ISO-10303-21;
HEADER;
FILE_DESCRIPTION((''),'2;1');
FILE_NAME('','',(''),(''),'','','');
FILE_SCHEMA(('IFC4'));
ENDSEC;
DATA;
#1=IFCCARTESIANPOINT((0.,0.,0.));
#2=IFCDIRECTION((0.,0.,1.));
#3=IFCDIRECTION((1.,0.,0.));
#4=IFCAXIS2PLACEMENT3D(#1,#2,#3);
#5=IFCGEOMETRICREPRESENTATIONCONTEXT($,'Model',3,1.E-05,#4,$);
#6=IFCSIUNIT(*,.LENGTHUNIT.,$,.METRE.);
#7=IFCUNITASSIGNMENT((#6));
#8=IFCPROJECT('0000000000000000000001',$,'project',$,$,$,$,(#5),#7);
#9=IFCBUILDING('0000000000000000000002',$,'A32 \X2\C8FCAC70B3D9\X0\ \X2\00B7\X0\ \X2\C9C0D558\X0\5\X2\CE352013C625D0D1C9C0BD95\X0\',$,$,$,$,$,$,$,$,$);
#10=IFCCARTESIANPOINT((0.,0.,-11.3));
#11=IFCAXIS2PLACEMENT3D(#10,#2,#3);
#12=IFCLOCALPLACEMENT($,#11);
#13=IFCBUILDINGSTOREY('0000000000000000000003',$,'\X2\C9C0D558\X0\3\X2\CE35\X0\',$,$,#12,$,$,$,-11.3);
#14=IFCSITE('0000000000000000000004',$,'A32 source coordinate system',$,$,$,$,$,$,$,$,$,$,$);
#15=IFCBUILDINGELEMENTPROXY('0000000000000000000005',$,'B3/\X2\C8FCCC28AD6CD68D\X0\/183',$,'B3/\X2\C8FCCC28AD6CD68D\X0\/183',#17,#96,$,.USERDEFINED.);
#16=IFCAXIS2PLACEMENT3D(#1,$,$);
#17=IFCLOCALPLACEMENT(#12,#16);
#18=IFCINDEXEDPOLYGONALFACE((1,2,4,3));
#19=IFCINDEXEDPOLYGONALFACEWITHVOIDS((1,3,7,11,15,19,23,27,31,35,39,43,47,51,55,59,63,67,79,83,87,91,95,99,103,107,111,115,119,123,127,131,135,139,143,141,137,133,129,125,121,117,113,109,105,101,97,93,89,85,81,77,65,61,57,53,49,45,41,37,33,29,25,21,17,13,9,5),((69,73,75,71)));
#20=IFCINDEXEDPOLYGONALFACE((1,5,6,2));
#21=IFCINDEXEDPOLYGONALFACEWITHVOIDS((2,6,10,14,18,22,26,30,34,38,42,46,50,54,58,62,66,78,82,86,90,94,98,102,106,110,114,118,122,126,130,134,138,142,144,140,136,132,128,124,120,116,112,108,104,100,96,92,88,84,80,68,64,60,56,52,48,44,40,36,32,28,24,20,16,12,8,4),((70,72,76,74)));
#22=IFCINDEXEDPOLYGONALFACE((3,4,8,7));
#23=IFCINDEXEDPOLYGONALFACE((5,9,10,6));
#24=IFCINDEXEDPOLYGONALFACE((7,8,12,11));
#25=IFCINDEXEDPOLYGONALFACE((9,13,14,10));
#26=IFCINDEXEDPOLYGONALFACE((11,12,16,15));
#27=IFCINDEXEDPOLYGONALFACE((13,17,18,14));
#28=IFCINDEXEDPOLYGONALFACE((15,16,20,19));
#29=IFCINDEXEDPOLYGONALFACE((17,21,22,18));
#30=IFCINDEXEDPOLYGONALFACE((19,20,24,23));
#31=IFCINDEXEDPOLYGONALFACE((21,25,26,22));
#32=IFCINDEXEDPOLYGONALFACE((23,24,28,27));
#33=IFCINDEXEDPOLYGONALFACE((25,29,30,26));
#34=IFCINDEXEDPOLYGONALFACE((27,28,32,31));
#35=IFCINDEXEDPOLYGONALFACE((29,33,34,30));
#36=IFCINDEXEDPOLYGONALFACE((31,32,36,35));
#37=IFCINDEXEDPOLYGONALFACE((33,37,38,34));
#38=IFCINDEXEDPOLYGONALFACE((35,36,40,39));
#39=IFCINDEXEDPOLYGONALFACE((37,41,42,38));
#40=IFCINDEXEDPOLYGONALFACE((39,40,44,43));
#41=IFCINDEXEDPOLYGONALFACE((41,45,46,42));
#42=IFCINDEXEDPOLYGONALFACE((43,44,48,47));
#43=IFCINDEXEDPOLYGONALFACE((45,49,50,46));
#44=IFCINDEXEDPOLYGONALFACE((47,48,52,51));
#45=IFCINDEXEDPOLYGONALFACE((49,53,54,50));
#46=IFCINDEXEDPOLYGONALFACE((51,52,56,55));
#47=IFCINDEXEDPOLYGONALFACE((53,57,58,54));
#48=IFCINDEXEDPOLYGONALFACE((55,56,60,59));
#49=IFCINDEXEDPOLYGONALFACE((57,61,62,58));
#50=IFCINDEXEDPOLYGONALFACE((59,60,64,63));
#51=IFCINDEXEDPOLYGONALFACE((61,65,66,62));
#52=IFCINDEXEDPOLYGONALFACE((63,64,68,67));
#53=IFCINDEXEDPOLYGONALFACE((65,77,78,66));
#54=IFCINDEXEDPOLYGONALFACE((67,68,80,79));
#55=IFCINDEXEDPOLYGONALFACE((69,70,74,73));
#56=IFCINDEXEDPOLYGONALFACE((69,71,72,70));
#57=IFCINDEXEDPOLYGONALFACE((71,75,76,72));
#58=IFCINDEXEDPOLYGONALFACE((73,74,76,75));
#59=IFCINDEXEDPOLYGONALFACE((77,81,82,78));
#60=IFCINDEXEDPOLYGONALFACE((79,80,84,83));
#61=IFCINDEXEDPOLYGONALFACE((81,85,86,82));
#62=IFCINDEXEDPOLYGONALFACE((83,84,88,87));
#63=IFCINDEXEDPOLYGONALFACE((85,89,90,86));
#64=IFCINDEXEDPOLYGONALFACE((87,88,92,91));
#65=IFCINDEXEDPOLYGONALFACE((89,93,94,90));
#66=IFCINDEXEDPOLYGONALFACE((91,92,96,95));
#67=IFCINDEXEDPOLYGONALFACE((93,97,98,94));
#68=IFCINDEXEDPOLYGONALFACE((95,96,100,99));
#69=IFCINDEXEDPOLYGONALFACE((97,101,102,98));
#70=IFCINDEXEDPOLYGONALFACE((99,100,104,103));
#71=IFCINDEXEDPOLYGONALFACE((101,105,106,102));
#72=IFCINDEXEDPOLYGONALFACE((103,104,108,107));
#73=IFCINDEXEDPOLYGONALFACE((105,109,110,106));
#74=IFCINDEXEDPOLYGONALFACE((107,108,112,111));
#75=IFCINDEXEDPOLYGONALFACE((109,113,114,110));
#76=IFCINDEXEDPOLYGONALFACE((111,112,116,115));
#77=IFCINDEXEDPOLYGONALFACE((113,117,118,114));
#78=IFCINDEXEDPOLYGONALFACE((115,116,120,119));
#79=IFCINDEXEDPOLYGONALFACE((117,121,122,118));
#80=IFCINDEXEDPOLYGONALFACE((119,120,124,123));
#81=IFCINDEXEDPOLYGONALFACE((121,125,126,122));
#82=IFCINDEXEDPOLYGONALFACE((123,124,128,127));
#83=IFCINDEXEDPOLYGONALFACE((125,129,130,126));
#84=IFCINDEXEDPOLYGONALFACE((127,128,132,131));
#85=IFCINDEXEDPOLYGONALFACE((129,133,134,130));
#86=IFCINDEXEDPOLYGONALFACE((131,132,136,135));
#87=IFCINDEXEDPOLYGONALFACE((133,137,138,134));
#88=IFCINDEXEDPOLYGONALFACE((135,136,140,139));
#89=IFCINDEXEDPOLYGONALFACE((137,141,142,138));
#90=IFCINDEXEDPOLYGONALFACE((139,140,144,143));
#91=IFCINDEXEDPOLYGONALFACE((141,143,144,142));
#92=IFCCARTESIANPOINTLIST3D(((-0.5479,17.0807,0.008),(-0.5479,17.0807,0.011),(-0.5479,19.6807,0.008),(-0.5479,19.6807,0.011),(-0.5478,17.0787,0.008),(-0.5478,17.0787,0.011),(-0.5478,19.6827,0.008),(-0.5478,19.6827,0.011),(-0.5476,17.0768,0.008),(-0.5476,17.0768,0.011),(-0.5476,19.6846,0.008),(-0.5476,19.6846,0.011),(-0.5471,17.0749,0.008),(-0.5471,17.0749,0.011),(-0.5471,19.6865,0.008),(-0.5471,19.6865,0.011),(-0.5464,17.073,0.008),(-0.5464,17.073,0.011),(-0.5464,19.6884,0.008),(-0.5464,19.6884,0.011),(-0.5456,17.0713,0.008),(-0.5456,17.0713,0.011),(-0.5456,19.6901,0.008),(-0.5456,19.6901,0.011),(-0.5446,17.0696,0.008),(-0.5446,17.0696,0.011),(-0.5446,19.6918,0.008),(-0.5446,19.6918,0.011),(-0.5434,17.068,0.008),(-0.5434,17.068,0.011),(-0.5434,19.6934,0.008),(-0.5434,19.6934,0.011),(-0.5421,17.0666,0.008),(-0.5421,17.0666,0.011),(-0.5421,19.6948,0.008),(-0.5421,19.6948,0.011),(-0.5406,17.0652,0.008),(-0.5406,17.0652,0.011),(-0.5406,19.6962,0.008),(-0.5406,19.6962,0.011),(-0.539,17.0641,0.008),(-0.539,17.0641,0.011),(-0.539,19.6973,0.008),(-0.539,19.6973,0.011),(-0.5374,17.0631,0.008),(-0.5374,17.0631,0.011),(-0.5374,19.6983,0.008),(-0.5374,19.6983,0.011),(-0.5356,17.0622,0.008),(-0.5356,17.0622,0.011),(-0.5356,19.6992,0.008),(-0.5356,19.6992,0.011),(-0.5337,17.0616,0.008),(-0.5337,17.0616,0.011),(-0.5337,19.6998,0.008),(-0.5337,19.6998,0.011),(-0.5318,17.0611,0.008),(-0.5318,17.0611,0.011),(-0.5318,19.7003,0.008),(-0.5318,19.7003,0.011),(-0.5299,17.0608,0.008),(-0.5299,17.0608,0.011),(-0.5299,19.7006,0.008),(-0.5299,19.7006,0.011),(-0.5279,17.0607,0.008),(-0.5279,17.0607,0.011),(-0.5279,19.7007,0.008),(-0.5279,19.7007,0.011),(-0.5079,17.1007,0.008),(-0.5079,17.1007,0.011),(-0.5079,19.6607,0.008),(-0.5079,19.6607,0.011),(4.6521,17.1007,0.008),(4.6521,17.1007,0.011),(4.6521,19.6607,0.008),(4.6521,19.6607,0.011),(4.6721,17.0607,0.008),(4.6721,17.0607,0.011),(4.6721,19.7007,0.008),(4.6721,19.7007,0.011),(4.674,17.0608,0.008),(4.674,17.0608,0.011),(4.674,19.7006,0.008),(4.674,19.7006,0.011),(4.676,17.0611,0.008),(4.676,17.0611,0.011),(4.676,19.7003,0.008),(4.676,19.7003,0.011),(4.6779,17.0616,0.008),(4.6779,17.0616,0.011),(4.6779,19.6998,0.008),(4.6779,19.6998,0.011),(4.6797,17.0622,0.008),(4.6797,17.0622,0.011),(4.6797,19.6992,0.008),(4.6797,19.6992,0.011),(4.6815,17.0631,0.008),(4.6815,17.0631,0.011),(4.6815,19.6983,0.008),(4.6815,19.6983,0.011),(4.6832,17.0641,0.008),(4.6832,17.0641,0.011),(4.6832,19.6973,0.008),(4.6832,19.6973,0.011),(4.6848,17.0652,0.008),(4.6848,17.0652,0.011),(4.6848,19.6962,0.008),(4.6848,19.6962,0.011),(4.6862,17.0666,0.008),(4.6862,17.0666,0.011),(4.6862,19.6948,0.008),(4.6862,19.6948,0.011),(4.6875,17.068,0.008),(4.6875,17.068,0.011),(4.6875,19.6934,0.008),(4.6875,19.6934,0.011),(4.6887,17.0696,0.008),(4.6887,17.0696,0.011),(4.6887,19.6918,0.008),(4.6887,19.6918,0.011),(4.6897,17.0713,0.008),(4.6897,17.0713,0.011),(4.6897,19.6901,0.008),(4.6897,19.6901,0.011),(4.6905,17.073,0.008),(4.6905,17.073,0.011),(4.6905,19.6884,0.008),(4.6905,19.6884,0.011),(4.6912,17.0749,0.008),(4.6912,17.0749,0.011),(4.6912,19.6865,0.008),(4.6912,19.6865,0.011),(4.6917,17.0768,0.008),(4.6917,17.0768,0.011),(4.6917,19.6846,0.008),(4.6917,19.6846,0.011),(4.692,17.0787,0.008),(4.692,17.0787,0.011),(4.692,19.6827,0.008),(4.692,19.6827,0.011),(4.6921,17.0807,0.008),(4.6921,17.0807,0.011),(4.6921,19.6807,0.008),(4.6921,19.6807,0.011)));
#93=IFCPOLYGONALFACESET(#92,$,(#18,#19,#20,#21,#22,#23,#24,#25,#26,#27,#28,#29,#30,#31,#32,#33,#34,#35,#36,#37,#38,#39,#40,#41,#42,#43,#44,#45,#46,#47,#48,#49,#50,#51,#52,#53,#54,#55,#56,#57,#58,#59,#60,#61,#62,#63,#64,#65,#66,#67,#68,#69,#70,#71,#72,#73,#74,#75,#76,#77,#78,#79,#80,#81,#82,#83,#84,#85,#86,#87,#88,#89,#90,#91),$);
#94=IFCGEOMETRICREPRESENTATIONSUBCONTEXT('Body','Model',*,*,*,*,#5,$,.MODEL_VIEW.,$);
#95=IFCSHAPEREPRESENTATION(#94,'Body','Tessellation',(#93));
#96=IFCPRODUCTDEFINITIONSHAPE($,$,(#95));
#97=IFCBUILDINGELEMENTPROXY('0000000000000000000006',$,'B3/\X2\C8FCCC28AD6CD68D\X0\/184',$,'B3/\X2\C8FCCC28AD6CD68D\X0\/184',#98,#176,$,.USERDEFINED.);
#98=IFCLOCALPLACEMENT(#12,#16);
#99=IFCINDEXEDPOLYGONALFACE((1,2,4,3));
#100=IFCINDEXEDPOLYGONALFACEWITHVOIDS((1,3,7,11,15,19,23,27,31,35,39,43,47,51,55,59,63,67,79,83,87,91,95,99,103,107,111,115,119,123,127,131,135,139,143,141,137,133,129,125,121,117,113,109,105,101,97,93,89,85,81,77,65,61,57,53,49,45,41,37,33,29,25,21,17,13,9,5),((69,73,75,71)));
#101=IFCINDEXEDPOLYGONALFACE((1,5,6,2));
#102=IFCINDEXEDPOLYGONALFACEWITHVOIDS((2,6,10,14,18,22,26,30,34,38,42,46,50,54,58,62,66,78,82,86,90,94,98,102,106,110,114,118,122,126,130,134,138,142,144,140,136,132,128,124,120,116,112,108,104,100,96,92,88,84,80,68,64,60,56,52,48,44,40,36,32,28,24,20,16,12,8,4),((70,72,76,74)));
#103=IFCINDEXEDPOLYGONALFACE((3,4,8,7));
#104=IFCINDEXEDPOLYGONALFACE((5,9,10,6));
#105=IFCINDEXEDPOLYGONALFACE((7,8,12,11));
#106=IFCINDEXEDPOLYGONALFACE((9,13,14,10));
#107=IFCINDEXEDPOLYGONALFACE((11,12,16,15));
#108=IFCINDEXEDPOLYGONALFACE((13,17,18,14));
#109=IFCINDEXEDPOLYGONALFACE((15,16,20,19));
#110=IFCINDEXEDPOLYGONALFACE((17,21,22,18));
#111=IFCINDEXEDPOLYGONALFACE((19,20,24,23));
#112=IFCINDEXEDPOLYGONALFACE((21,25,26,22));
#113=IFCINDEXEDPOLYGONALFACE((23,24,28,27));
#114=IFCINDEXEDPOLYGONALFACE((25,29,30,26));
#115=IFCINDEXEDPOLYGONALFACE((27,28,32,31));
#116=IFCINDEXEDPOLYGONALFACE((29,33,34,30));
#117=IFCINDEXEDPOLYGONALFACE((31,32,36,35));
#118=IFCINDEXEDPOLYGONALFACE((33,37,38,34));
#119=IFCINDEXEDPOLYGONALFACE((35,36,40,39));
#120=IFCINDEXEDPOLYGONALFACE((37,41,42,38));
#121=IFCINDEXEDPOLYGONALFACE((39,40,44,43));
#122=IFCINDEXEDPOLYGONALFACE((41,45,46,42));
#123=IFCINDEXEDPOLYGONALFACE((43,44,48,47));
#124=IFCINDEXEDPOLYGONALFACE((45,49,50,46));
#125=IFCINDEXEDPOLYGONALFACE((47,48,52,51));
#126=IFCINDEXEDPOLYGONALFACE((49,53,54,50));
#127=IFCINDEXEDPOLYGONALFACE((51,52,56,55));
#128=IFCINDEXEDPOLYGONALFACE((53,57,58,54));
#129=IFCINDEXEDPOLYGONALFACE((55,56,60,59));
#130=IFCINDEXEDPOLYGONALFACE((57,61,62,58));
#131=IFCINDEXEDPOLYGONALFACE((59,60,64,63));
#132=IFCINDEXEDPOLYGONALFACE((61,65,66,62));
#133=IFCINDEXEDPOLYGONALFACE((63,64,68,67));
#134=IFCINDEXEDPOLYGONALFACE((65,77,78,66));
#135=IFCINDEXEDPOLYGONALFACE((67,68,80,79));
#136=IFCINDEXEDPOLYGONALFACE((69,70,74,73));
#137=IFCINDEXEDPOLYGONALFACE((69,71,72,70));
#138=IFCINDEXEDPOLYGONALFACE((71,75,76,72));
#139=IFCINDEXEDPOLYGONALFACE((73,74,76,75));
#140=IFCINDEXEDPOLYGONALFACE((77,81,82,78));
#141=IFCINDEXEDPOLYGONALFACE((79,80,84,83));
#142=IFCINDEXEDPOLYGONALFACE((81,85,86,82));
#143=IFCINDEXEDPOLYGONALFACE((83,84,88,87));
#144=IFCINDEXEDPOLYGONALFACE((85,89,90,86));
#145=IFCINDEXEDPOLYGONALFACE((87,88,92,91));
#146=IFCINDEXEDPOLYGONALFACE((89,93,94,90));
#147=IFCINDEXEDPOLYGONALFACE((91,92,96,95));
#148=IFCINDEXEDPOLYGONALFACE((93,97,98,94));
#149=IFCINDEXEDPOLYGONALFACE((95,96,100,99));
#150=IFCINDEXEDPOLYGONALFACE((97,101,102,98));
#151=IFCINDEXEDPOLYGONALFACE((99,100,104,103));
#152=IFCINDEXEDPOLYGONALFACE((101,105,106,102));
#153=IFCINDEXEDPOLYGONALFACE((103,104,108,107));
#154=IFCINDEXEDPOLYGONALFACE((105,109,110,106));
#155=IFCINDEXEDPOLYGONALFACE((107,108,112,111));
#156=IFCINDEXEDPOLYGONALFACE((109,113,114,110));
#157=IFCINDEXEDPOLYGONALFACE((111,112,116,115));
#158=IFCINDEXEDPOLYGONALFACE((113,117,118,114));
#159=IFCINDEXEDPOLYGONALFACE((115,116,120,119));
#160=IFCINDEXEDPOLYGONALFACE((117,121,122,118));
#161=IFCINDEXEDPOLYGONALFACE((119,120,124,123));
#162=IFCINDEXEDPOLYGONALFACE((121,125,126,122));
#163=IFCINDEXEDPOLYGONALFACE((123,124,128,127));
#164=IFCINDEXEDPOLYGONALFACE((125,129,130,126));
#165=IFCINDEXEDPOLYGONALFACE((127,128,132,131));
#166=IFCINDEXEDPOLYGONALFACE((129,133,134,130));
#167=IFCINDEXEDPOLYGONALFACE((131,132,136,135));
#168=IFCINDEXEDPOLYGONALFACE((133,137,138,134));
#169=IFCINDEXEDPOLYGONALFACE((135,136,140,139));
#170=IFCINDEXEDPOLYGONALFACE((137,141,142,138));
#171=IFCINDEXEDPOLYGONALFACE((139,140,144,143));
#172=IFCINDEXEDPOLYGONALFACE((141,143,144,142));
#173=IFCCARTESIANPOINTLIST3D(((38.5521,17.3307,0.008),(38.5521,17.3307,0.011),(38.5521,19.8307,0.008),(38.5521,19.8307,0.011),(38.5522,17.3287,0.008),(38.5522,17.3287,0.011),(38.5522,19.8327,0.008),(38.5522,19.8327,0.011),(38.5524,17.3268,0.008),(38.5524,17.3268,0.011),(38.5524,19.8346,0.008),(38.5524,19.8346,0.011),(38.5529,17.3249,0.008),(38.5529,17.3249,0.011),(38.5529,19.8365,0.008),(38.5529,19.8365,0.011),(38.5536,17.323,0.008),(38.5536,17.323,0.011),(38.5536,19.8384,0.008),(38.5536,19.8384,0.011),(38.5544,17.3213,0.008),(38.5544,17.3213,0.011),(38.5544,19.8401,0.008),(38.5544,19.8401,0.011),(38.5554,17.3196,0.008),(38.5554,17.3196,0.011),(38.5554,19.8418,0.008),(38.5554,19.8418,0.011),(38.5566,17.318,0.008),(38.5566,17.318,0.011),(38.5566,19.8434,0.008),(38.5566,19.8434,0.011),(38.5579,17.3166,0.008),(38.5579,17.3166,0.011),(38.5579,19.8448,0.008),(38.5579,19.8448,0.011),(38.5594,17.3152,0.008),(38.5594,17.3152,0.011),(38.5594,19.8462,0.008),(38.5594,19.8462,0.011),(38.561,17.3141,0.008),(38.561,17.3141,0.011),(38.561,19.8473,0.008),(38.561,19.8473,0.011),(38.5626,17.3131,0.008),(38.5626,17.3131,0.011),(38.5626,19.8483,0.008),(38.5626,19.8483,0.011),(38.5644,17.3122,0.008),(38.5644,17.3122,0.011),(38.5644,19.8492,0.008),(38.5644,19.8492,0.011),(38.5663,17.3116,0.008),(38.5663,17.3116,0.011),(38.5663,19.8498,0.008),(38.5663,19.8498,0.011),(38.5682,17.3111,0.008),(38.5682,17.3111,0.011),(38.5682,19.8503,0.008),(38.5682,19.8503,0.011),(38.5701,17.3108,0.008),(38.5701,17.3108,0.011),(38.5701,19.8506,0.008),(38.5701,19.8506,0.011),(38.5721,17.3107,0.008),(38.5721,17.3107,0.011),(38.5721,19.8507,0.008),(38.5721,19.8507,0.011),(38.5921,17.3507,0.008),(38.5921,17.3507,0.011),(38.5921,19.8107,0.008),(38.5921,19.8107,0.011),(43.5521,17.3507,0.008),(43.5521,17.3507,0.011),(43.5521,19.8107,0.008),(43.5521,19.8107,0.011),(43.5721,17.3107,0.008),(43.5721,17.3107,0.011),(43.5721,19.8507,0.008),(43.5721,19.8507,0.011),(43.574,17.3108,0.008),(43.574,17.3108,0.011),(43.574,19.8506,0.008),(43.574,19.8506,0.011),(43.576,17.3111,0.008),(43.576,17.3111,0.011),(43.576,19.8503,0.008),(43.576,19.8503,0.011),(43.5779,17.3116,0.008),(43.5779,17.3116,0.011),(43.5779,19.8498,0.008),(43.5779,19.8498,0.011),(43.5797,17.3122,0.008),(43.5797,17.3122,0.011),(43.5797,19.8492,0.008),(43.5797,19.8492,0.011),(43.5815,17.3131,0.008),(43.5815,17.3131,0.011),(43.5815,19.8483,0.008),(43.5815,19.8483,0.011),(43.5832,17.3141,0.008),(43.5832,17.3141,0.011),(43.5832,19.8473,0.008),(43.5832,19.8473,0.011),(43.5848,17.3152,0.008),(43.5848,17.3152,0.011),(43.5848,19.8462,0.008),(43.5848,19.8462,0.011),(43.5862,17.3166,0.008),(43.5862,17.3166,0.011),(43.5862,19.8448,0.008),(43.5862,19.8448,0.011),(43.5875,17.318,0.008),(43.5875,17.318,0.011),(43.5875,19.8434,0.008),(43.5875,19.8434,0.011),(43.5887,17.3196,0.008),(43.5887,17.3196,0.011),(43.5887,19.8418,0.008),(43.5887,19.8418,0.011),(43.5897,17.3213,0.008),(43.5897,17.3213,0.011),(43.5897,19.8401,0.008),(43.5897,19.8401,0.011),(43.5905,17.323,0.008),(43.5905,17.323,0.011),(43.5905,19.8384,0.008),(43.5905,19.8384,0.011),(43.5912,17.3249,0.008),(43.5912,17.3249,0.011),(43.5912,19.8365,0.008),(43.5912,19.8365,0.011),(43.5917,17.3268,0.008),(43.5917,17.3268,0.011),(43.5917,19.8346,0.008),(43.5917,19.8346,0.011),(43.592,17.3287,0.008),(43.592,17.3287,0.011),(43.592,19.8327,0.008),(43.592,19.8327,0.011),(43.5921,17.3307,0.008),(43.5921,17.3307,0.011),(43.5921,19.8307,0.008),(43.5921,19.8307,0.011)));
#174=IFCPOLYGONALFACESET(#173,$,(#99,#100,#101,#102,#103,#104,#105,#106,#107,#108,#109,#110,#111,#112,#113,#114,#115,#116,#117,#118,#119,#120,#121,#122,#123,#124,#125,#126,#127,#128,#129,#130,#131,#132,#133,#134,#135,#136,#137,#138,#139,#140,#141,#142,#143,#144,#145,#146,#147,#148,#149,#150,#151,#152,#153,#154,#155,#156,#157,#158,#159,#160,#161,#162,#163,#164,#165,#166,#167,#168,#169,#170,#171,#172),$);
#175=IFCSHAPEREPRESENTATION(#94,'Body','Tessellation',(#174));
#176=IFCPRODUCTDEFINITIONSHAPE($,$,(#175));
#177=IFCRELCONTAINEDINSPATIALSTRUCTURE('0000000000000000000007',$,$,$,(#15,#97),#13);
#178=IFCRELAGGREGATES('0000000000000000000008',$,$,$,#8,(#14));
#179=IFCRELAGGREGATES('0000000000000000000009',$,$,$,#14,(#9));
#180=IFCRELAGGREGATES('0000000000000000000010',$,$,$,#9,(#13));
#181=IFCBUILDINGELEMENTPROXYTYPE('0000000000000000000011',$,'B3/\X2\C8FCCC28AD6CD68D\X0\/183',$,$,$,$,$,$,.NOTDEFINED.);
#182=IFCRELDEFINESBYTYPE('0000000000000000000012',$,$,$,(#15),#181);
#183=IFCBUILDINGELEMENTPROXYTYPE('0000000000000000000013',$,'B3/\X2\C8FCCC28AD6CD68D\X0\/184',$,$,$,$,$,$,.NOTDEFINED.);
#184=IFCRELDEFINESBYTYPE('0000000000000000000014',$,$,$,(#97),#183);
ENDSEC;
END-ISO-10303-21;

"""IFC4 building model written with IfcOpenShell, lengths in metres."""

from ifc_helpers import new_model, si_unit, frame, origin, origin_with_axes, place, context, subcontext, project, spatial, polyline, outline, extrude, source, transform, mapped, type_object, type_shapes, element, save


model = new_model("IFC4")

# Units and contexts
model_context = context("Model", 3, precision=1e-05, world=origin_with_axes())
body_context = subcontext(model_context, "Body", "Model", "MODEL_VIEW")
ifc_project = project(units=[si_unit("LENGTHUNIT", "METRE")], contexts=[model_context])

# Site, building, storey
site = spatial("IfcSite", under=ifc_project, Name="A32 source coordinate system")
building = spatial("IfcBuilding", under=site, Name="A32 주거동 · 지하5층–옥탑지붕")
storey_placement = place(None, frame((0.0, 0.0, -11.3), z_axis=(0.0, 0.0, 1.0), x_axis=(1.0, 0.0, 0.0)))
storey = spatial("IfcBuildingStorey", under=building, at=storey_placement, Name="지하3층", Elevation=-11.3)

# Building element proxies
building_element_proxy_type_1 = type_object("IfcBuildingElementProxyType", Name="B3/주차구획/183", PredefinedType="NOTDEFINED")
shared_shape_1 = source(origin(), body_context, "Body", "SweptSolid", [
    extrude(outline(polyline([(-0.5279, 17.0607), (-0.5299, 17.0608), (-0.5318, 17.0611), (-0.5337, 17.0616), (-0.5356, 17.0622), (-0.5374, 17.0631), (-0.539, 17.0641), (-0.5406, 17.0652), (-0.5421, 17.0666), (-0.5434, 17.068), (-0.5446, 17.0696), (-0.5456, 17.0713), (-0.5464, 17.073), (-0.5471, 17.0749), (-0.5476, 17.0768), (-0.5478, 17.0787), (-0.5479, 17.0807), (-0.5479, 19.6807), (-0.5478, 19.6827), (-0.5476, 19.6846), (-0.5471, 19.6865), (-0.5464, 19.6884), (-0.5456, 19.6901), (-0.5446, 19.6918), (-0.5434, 19.6934), (-0.5421, 19.6948), (-0.5406, 19.6962), (-0.539, 19.6973), (-0.5374, 19.6983), (-0.5356, 19.6992), (-0.5337, 19.6998), (-0.5318, 19.7003), (-0.5299, 19.7006), (-0.5279, 19.7007), (4.6721, 19.7007), (4.674, 19.7006), (4.676, 19.7003), (4.6779, 19.6998), (4.6797, 19.6992), (4.6815, 19.6983), (4.6832, 19.6973), (4.6848, 19.6962), (4.6862, 19.6948), (4.6875, 19.6934), (4.6887, 19.6918), (4.6897, 19.6901), (4.6905, 19.6884), (4.6912, 19.6865), (4.6917, 19.6846), (4.692, 19.6827), (4.6921, 19.6807), (4.6921, 17.0807), (4.692, 17.0787), (4.6917, 17.0768), (4.6912, 17.0749), (4.6905, 17.073), (4.6897, 17.0713), (4.6887, 17.0696), (4.6875, 17.068), (4.6862, 17.0666), (4.6848, 17.0652), (4.6832, 17.0641), (4.6815, 17.0631), (4.6797, 17.0622), (4.6779, 17.0616), (4.676, 17.0611), (4.674, 17.0608), (4.6721, 17.0607), (-0.5279, 17.0607)]), holes=[polyline([(-0.5079, 17.1007), (4.6521, 17.1007), (4.6521, 19.6607), (-0.5079, 19.6607), (-0.5079, 17.1007)])]), frame((0.0, 0.0, 0.008)), (0.0, 0.0, 1.0), 0.003),
])
type_shapes(building_element_proxy_type_1, [shared_shape_1])
proxy_1_placement = place(storey_placement, origin_with_axes())
element("IfcBuildingElementProxy", 1, at=proxy_1_placement, inside=storey, type_object=building_element_proxy_type_1, Name="B3/주차구획/183", ObjectType="B3/주차구획/183", PredefinedType="USERDEFINED", context=body_context, shape_type="MappedRepresentation", body=[
    mapped(shared_shape_1, transform((0.0, 0.0, 0.0), scale=1.0)),
])
building_element_proxy_type_2 = type_object("IfcBuildingElementProxyType", Name="B3/주차구획/184", PredefinedType="NOTDEFINED")
shared_shape_2 = source(origin(), body_context, "Body", "SweptSolid", [
    extrude(outline(polyline([(43.5721, 19.8507), (43.574, 19.8506), (43.576, 19.8503), (43.5779, 19.8498), (43.5797, 19.8492), (43.5815, 19.8483), (43.5832, 19.8473), (43.5848, 19.8462), (43.5862, 19.8448), (43.5875, 19.8434), (43.5887, 19.8418), (43.5897, 19.8401), (43.5905, 19.8384), (43.5912, 19.8365), (43.5917, 19.8346), (43.592, 19.8327), (43.5921, 19.8307), (43.5921, 17.3307), (43.592, 17.3287), (43.5917, 17.3268), (43.5912, 17.3249), (43.5905, 17.323), (43.5897, 17.3213), (43.5887, 17.3196), (43.5875, 17.318), (43.5862, 17.3166), (43.5848, 17.3152), (43.5832, 17.3141), (43.5815, 17.3131), (43.5797, 17.3122), (43.5779, 17.3116), (43.576, 17.3111), (43.574, 17.3108), (43.5721, 17.3107), (38.5721, 17.3107), (38.5701, 17.3108), (38.5682, 17.3111), (38.5663, 17.3116), (38.5644, 17.3122), (38.5626, 17.3131), (38.561, 17.3141), (38.5594, 17.3152), (38.5579, 17.3166), (38.5566, 17.318), (38.5554, 17.3196), (38.5544, 17.3213), (38.5536, 17.323), (38.5529, 17.3249), (38.5524, 17.3268), (38.5522, 17.3287), (38.5521, 17.3307), (38.5521, 19.8307), (38.5522, 19.8327), (38.5524, 19.8346), (38.5529, 19.8365), (38.5536, 19.8384), (38.5544, 19.8401), (38.5554, 19.8418), (38.5566, 19.8434), (38.5579, 19.8448), (38.5594, 19.8462), (38.561, 19.8473), (38.5626, 19.8483), (38.5644, 19.8492), (38.5663, 19.8498), (38.5682, 19.8503), (38.5701, 19.8506), (38.5721, 19.8507), (43.5721, 19.8507)]), holes=[polyline([(43.5521, 19.8107), (38.5921, 19.8107), (38.5921, 17.3507), (43.5521, 17.3507), (43.5521, 19.8107)])]), frame((0.0, 0.0, 0.008)), (0.0, 0.0, 1.0), 0.003),
])
type_shapes(building_element_proxy_type_2, [shared_shape_2])
proxy_2_placement = place(storey_placement, origin_with_axes())
element("IfcBuildingElementProxy", 2, at=proxy_2_placement, inside=storey, type_object=building_element_proxy_type_2, Name="B3/주차구획/184", ObjectType="B3/주차구획/184", PredefinedType="USERDEFINED", context=body_context, shape_type="MappedRepresentation", body=[
    mapped(shared_shape_2, transform((0.0, 0.0, 0.0), scale=1.0)),
])

save(model, "model.ifc")
